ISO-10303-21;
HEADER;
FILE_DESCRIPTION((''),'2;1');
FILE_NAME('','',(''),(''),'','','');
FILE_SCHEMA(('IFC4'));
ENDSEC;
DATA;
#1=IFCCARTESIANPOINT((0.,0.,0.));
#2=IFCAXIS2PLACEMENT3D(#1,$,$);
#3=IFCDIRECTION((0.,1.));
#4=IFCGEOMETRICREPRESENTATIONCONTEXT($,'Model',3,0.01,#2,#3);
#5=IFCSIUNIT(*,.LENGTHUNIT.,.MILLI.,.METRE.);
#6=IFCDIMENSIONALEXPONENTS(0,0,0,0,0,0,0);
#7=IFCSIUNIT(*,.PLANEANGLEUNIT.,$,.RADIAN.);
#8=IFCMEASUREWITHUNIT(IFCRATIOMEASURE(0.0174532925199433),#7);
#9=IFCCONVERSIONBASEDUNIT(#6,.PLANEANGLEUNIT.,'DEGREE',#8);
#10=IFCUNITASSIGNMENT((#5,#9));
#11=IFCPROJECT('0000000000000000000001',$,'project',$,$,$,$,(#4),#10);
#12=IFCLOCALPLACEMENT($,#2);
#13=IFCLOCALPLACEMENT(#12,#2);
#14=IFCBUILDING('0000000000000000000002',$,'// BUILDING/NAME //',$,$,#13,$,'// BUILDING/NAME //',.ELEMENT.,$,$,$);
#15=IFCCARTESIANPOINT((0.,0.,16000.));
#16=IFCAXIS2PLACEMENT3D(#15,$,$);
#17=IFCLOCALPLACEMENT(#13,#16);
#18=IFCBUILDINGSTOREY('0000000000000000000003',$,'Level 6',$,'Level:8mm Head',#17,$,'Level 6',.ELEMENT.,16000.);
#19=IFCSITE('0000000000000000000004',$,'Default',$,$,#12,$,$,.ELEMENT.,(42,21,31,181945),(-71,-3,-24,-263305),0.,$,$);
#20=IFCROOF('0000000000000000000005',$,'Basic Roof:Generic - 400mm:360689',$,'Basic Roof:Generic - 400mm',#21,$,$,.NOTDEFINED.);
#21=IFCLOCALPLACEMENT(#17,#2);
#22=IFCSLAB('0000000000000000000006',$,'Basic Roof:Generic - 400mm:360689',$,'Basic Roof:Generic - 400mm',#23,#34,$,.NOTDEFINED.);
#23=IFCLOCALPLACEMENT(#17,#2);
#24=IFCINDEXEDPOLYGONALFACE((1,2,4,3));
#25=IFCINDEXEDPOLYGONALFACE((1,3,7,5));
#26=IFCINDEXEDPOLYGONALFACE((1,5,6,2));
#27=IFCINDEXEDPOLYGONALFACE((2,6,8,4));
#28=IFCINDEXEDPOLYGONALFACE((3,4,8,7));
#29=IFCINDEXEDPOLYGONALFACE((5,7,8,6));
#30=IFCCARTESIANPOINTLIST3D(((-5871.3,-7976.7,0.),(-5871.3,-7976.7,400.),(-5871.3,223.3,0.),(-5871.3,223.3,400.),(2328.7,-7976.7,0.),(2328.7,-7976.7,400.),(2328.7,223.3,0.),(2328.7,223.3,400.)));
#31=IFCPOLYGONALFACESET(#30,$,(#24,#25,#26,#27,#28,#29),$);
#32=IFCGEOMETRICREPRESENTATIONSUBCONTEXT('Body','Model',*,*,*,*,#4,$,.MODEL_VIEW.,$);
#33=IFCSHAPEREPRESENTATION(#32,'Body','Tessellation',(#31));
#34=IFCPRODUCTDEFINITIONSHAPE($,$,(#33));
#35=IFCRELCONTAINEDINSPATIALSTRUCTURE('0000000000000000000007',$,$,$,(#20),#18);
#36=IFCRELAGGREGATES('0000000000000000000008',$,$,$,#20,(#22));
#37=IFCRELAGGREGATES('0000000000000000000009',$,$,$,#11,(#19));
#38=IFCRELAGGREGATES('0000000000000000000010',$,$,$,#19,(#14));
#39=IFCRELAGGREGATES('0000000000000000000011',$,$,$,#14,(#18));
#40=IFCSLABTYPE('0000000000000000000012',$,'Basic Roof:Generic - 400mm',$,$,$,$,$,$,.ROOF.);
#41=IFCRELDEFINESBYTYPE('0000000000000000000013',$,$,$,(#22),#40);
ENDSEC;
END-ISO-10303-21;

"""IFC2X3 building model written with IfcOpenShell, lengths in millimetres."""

from ifc_helpers import new_model, entity, si_unit, converted_unit, direction, frame, frame_2d, origin, place, context, subcontext, project, spatial, rectangle, extrude, type_object, element, aggregate, save


model = new_model("IFC2X3")

# Units and contexts
model_context = context("Model", 3, precision=0.01, world=origin(), true_north=direction((0.0, 1.0)))
body_context = subcontext(model_context, "Body", "Model", "MODEL_VIEW")
ifc_project = project(units=[si_unit("LENGTHUNIT", "METRE", prefix="MILLI"), converted_unit("PLANEANGLEUNIT", "DEGREE", entity("IfcRatioMeasure", 0.0174532925199433), si_unit("PLANEANGLEUNIT", "RADIAN"), dimensions=[0, 0, 0, 0, 0, 0, 0])], contexts=[model_context])

# Site, building, storey
site_placement = place(None, origin())
site = spatial("IfcSite", under=ifc_project, at=site_placement, Name="Default", CompositionType="ELEMENT", RefLatitude=(42, 21, 31, 181945), RefLongitude=(-71, -3, -24, -263305), RefElevation=0.0)
building_placement = place(site_placement, origin())
building = spatial("IfcBuilding", under=site, at=building_placement, Name="// BUILDING/NAME //", LongName="// BUILDING/NAME //", CompositionType="ELEMENT")
storey_placement = place(building_placement, frame((0.0, 0.0, 16000.0)))
storey = spatial("IfcBuildingStorey", under=building, at=storey_placement, Name="Level 6", ObjectType="Level:8mm Head", LongName="Level 6", CompositionType="ELEMENT", Elevation=16000.0)

# Roof, slab
roof_placement = place(storey_placement, frame((-5871.3, -7976.7, 0.0)))
roof = element("IfcRoof", 1, at=roof_placement, inside=storey, Name="Basic Roof:Generic - 400mm:360689", ObjectType="Basic Roof:Generic - 400mm", ShapeType="NOTDEFINED")
slab_type = type_object("IfcSlabType", Name="Basic Roof:Generic - 400mm", PredefinedType="ROOF")
slab_placement = place(roof_placement, origin())
slab = element("IfcSlab", 2, at=slab_placement, type_object=slab_type, Name="Basic Roof:Generic - 400mm:360689", ObjectType="Basic Roof:Generic - 400mm", PredefinedType="NOTDEFINED", context=body_context, shape_type="SweptSolid", body=[
    extrude(rectangle(XDim=8200.0, YDim=8200.0, at=frame_2d((0.0, 0.0), x_axis=(1.0, 0.0))), frame((4100.0, 4100.0, 0.0)), (0.0, 0.0, 1.0), 400.0),
])
aggregate(roof, [slab])

save(model, "model.ifc")
